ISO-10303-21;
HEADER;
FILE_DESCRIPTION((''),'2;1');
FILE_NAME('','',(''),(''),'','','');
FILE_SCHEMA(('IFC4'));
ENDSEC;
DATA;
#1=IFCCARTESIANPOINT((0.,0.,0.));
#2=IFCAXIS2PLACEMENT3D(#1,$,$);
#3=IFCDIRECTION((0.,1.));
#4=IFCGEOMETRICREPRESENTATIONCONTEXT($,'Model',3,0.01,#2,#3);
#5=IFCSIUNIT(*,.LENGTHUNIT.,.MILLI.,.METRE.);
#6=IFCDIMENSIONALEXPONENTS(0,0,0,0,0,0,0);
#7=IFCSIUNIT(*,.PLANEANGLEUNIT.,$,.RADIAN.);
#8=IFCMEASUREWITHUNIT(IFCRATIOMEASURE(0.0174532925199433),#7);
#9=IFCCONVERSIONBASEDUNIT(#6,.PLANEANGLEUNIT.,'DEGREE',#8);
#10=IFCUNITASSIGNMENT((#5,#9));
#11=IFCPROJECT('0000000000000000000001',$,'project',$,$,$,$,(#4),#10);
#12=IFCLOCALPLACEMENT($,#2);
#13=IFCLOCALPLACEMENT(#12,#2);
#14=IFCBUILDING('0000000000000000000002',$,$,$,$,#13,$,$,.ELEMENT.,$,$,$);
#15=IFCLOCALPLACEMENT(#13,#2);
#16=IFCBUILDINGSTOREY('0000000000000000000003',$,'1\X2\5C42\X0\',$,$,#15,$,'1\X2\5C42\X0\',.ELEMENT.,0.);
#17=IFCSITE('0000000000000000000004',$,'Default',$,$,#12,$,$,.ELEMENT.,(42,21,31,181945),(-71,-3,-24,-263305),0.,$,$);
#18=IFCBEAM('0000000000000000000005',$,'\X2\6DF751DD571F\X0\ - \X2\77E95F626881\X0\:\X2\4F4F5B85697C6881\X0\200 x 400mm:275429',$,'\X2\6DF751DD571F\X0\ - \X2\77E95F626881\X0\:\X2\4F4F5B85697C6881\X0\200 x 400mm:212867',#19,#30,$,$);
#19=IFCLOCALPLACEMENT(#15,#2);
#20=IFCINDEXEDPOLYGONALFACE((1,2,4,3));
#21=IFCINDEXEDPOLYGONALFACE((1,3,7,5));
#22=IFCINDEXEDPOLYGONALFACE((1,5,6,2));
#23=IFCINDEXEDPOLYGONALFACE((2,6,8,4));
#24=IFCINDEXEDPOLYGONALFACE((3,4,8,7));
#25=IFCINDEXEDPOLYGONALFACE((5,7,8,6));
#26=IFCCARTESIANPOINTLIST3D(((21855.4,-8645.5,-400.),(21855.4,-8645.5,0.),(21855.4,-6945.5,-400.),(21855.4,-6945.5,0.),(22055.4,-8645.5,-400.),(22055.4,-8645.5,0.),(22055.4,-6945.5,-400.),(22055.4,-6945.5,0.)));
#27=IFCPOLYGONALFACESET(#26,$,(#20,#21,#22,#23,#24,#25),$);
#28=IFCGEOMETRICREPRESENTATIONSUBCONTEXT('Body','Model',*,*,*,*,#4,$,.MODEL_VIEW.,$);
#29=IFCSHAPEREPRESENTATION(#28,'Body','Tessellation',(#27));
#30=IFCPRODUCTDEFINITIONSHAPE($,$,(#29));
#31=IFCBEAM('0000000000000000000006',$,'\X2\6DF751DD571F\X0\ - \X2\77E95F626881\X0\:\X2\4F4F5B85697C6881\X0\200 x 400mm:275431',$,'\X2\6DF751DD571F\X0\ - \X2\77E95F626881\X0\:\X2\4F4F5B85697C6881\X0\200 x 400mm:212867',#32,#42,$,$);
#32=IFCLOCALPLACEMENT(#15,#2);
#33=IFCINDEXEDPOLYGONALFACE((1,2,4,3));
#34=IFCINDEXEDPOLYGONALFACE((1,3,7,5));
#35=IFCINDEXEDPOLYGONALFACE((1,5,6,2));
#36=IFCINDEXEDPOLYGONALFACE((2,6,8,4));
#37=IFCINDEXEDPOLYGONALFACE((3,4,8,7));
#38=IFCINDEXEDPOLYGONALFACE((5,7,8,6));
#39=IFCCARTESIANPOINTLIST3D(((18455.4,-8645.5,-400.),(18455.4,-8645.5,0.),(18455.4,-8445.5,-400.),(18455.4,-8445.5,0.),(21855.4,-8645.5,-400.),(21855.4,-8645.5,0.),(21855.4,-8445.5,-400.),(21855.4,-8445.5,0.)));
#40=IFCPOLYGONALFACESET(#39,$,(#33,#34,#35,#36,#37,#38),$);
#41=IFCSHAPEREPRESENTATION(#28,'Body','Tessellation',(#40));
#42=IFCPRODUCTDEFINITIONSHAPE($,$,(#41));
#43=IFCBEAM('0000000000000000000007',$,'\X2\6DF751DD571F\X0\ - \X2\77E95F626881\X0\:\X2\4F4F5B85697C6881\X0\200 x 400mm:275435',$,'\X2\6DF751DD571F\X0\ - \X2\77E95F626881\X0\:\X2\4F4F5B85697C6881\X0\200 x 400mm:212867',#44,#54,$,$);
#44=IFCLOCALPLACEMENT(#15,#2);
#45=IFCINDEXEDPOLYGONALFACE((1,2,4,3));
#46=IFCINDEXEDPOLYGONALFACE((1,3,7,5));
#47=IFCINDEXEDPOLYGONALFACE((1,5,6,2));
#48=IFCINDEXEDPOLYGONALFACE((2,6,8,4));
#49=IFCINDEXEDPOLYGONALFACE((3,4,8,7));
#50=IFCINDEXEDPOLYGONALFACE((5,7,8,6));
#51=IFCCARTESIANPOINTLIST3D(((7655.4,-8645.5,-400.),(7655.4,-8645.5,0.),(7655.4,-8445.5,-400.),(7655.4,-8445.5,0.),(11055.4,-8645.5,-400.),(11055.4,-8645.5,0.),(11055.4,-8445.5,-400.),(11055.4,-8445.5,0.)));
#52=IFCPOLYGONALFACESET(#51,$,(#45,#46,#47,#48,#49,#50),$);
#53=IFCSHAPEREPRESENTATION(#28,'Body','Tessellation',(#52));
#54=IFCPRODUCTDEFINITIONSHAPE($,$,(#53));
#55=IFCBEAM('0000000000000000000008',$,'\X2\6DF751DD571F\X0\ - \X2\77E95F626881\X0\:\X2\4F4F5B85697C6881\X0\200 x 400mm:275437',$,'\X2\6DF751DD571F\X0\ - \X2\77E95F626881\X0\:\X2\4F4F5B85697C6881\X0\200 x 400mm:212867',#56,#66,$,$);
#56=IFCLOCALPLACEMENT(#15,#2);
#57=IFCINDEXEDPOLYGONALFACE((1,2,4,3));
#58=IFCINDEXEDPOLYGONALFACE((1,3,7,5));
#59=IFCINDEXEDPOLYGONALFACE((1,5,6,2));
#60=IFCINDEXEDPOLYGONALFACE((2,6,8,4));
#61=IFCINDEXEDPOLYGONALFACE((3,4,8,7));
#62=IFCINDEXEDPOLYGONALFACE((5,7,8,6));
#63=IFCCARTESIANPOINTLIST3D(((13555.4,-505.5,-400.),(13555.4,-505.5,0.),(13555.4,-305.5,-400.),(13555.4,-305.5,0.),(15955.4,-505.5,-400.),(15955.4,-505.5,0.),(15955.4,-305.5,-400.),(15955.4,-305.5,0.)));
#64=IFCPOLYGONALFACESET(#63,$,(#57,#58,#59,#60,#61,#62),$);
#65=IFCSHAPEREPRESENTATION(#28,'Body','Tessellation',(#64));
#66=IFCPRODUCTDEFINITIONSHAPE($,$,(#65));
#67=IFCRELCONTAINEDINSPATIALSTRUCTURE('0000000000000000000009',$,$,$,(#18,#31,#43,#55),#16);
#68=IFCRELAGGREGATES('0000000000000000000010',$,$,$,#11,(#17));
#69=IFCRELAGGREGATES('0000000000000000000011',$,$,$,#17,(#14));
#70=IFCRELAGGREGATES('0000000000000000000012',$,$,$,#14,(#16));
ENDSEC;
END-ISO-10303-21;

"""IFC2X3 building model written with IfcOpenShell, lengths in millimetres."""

from ifc_helpers import new_model, entity, si_unit, converted_unit, direction, frame, frame_2d, origin, place, context, subcontext, project, spatial, rectangle, extrude, element, save


model = new_model("IFC2X3")

# Units and contexts
model_context = context("Model", 3, precision=0.01, world=origin(), true_north=direction((0.0, 1.0)))
body_context = subcontext(model_context, "Body", "Model", "MODEL_VIEW")
ifc_project = project(units=[si_unit("LENGTHUNIT", "METRE", prefix="MILLI"), converted_unit("PLANEANGLEUNIT", "DEGREE", entity("IfcRatioMeasure", 0.0174532925199433), si_unit("PLANEANGLEUNIT", "RADIAN"), dimensions=[0, 0, 0, 0, 0, 0, 0])], contexts=[model_context])

# Site, building, storey
site_placement = place(None, origin())
site = spatial("IfcSite", under=ifc_project, at=site_placement, Name="Default", CompositionType="ELEMENT", RefLatitude=(42, 21, 31, 181945), RefLongitude=(-71, -3, -24, -263305), RefElevation=0.0)
building_placement = place(site_placement, origin())
building = spatial("IfcBuilding", under=site, at=building_placement, CompositionType="ELEMENT")
storey_placement = place(building_placement, origin())
storey = spatial("IfcBuildingStorey", under=building, at=storey_placement, Name="1层", LongName="1层", CompositionType="ELEMENT", Elevation=0.0)

# Beams
beam_1_placement = place(storey_placement, frame((21955.4, -6745.5, 0.0), z_axis=(0.0, 0.0, 1.0), x_axis=(0.0, -1.0, 0.0)))
element("IfcBeam", 1, at=beam_1_placement, inside=storey, Name="混凝土 - 矩形梁:住宅楼梁200 x 400mm:275429", ObjectType="混凝土 - 矩形梁:住宅楼梁200 x 400mm:212867", context=body_context, shape_type="SweptSolid", body=[
    extrude(rectangle(XDim=400.0, YDim=200.0, at=frame_2d((0.0, 0.0), x_axis=(1.0, 0.0))), frame((200.0, 0.0, -200.0), z_axis=(1.0, 0.0, 0.0), x_axis=(0.0, 0.0, -1.0)), (0.0, 0.0, 1.0), 1700.0),
])
beam_2_placement = place(storey_placement, frame((21955.4, -8545.5, 0.0), z_axis=(0.0, 0.0, 1.0), x_axis=(-1.0, 0.0, 0.0)))
element("IfcBeam", 2, at=beam_2_placement, inside=storey, Name="混凝土 - 矩形梁:住宅楼梁200 x 400mm:275431", ObjectType="混凝土 - 矩形梁:住宅楼梁200 x 400mm:212867", context=body_context, shape_type="SweptSolid", body=[
    extrude(rectangle(XDim=400.0, YDim=200.0, at=frame_2d((0.0, 0.0), x_axis=(1.0, 0.0))), frame((100.0, 0.0, -200.0), z_axis=(1.0, 0.0, 0.0), x_axis=(0.0, 0.0, -1.0)), (0.0, 0.0, 1.0), 3400.0),
])
beam_3_placement = place(storey_placement, frame((7555.4, -8545.5, 0.0)))
element("IfcBeam", 3, at=beam_3_placement, inside=storey, Name="混凝土 - 矩形梁:住宅楼梁200 x 400mm:275435", ObjectType="混凝土 - 矩形梁:住宅楼梁200 x 400mm:212867", context=body_context, shape_type="SweptSolid", body=[
    extrude(rectangle(XDim=400.0, YDim=200.0, at=frame_2d((0.0, 0.0), x_axis=(1.0, 0.0))), frame((100.0, 0.0, -200.0), z_axis=(1.0, 0.0, 0.0), x_axis=(0.0, 0.0, -1.0)), (0.0, 0.0, 1.0), 3400.0),
])
beam_4_placement = place(storey_placement, frame((16055.4, -405.5, 0.0), z_axis=(0.0, 0.0, 1.0), x_axis=(-1.0, 0.0, 0.0)))
element("IfcBeam", 4, at=beam_4_placement, inside=storey, Name="混凝土 - 矩形梁:住宅楼梁200 x 400mm:275437", ObjectType="混凝土 - 矩形梁:住宅楼梁200 x 400mm:212867", context=body_context, shape_type="SweptSolid", body=[
    extrude(rectangle(XDim=400.0, YDim=200.0, at=frame_2d((0.0, 0.0), x_axis=(1.0, 0.0))), frame((100.0, 0.0, -200.0), z_axis=(1.0, 0.0, 0.0), x_axis=(0.0, 0.0, -1.0)), (0.0, 0.0, 1.0), 2400.0),
])

save(model, "model.ifc")
